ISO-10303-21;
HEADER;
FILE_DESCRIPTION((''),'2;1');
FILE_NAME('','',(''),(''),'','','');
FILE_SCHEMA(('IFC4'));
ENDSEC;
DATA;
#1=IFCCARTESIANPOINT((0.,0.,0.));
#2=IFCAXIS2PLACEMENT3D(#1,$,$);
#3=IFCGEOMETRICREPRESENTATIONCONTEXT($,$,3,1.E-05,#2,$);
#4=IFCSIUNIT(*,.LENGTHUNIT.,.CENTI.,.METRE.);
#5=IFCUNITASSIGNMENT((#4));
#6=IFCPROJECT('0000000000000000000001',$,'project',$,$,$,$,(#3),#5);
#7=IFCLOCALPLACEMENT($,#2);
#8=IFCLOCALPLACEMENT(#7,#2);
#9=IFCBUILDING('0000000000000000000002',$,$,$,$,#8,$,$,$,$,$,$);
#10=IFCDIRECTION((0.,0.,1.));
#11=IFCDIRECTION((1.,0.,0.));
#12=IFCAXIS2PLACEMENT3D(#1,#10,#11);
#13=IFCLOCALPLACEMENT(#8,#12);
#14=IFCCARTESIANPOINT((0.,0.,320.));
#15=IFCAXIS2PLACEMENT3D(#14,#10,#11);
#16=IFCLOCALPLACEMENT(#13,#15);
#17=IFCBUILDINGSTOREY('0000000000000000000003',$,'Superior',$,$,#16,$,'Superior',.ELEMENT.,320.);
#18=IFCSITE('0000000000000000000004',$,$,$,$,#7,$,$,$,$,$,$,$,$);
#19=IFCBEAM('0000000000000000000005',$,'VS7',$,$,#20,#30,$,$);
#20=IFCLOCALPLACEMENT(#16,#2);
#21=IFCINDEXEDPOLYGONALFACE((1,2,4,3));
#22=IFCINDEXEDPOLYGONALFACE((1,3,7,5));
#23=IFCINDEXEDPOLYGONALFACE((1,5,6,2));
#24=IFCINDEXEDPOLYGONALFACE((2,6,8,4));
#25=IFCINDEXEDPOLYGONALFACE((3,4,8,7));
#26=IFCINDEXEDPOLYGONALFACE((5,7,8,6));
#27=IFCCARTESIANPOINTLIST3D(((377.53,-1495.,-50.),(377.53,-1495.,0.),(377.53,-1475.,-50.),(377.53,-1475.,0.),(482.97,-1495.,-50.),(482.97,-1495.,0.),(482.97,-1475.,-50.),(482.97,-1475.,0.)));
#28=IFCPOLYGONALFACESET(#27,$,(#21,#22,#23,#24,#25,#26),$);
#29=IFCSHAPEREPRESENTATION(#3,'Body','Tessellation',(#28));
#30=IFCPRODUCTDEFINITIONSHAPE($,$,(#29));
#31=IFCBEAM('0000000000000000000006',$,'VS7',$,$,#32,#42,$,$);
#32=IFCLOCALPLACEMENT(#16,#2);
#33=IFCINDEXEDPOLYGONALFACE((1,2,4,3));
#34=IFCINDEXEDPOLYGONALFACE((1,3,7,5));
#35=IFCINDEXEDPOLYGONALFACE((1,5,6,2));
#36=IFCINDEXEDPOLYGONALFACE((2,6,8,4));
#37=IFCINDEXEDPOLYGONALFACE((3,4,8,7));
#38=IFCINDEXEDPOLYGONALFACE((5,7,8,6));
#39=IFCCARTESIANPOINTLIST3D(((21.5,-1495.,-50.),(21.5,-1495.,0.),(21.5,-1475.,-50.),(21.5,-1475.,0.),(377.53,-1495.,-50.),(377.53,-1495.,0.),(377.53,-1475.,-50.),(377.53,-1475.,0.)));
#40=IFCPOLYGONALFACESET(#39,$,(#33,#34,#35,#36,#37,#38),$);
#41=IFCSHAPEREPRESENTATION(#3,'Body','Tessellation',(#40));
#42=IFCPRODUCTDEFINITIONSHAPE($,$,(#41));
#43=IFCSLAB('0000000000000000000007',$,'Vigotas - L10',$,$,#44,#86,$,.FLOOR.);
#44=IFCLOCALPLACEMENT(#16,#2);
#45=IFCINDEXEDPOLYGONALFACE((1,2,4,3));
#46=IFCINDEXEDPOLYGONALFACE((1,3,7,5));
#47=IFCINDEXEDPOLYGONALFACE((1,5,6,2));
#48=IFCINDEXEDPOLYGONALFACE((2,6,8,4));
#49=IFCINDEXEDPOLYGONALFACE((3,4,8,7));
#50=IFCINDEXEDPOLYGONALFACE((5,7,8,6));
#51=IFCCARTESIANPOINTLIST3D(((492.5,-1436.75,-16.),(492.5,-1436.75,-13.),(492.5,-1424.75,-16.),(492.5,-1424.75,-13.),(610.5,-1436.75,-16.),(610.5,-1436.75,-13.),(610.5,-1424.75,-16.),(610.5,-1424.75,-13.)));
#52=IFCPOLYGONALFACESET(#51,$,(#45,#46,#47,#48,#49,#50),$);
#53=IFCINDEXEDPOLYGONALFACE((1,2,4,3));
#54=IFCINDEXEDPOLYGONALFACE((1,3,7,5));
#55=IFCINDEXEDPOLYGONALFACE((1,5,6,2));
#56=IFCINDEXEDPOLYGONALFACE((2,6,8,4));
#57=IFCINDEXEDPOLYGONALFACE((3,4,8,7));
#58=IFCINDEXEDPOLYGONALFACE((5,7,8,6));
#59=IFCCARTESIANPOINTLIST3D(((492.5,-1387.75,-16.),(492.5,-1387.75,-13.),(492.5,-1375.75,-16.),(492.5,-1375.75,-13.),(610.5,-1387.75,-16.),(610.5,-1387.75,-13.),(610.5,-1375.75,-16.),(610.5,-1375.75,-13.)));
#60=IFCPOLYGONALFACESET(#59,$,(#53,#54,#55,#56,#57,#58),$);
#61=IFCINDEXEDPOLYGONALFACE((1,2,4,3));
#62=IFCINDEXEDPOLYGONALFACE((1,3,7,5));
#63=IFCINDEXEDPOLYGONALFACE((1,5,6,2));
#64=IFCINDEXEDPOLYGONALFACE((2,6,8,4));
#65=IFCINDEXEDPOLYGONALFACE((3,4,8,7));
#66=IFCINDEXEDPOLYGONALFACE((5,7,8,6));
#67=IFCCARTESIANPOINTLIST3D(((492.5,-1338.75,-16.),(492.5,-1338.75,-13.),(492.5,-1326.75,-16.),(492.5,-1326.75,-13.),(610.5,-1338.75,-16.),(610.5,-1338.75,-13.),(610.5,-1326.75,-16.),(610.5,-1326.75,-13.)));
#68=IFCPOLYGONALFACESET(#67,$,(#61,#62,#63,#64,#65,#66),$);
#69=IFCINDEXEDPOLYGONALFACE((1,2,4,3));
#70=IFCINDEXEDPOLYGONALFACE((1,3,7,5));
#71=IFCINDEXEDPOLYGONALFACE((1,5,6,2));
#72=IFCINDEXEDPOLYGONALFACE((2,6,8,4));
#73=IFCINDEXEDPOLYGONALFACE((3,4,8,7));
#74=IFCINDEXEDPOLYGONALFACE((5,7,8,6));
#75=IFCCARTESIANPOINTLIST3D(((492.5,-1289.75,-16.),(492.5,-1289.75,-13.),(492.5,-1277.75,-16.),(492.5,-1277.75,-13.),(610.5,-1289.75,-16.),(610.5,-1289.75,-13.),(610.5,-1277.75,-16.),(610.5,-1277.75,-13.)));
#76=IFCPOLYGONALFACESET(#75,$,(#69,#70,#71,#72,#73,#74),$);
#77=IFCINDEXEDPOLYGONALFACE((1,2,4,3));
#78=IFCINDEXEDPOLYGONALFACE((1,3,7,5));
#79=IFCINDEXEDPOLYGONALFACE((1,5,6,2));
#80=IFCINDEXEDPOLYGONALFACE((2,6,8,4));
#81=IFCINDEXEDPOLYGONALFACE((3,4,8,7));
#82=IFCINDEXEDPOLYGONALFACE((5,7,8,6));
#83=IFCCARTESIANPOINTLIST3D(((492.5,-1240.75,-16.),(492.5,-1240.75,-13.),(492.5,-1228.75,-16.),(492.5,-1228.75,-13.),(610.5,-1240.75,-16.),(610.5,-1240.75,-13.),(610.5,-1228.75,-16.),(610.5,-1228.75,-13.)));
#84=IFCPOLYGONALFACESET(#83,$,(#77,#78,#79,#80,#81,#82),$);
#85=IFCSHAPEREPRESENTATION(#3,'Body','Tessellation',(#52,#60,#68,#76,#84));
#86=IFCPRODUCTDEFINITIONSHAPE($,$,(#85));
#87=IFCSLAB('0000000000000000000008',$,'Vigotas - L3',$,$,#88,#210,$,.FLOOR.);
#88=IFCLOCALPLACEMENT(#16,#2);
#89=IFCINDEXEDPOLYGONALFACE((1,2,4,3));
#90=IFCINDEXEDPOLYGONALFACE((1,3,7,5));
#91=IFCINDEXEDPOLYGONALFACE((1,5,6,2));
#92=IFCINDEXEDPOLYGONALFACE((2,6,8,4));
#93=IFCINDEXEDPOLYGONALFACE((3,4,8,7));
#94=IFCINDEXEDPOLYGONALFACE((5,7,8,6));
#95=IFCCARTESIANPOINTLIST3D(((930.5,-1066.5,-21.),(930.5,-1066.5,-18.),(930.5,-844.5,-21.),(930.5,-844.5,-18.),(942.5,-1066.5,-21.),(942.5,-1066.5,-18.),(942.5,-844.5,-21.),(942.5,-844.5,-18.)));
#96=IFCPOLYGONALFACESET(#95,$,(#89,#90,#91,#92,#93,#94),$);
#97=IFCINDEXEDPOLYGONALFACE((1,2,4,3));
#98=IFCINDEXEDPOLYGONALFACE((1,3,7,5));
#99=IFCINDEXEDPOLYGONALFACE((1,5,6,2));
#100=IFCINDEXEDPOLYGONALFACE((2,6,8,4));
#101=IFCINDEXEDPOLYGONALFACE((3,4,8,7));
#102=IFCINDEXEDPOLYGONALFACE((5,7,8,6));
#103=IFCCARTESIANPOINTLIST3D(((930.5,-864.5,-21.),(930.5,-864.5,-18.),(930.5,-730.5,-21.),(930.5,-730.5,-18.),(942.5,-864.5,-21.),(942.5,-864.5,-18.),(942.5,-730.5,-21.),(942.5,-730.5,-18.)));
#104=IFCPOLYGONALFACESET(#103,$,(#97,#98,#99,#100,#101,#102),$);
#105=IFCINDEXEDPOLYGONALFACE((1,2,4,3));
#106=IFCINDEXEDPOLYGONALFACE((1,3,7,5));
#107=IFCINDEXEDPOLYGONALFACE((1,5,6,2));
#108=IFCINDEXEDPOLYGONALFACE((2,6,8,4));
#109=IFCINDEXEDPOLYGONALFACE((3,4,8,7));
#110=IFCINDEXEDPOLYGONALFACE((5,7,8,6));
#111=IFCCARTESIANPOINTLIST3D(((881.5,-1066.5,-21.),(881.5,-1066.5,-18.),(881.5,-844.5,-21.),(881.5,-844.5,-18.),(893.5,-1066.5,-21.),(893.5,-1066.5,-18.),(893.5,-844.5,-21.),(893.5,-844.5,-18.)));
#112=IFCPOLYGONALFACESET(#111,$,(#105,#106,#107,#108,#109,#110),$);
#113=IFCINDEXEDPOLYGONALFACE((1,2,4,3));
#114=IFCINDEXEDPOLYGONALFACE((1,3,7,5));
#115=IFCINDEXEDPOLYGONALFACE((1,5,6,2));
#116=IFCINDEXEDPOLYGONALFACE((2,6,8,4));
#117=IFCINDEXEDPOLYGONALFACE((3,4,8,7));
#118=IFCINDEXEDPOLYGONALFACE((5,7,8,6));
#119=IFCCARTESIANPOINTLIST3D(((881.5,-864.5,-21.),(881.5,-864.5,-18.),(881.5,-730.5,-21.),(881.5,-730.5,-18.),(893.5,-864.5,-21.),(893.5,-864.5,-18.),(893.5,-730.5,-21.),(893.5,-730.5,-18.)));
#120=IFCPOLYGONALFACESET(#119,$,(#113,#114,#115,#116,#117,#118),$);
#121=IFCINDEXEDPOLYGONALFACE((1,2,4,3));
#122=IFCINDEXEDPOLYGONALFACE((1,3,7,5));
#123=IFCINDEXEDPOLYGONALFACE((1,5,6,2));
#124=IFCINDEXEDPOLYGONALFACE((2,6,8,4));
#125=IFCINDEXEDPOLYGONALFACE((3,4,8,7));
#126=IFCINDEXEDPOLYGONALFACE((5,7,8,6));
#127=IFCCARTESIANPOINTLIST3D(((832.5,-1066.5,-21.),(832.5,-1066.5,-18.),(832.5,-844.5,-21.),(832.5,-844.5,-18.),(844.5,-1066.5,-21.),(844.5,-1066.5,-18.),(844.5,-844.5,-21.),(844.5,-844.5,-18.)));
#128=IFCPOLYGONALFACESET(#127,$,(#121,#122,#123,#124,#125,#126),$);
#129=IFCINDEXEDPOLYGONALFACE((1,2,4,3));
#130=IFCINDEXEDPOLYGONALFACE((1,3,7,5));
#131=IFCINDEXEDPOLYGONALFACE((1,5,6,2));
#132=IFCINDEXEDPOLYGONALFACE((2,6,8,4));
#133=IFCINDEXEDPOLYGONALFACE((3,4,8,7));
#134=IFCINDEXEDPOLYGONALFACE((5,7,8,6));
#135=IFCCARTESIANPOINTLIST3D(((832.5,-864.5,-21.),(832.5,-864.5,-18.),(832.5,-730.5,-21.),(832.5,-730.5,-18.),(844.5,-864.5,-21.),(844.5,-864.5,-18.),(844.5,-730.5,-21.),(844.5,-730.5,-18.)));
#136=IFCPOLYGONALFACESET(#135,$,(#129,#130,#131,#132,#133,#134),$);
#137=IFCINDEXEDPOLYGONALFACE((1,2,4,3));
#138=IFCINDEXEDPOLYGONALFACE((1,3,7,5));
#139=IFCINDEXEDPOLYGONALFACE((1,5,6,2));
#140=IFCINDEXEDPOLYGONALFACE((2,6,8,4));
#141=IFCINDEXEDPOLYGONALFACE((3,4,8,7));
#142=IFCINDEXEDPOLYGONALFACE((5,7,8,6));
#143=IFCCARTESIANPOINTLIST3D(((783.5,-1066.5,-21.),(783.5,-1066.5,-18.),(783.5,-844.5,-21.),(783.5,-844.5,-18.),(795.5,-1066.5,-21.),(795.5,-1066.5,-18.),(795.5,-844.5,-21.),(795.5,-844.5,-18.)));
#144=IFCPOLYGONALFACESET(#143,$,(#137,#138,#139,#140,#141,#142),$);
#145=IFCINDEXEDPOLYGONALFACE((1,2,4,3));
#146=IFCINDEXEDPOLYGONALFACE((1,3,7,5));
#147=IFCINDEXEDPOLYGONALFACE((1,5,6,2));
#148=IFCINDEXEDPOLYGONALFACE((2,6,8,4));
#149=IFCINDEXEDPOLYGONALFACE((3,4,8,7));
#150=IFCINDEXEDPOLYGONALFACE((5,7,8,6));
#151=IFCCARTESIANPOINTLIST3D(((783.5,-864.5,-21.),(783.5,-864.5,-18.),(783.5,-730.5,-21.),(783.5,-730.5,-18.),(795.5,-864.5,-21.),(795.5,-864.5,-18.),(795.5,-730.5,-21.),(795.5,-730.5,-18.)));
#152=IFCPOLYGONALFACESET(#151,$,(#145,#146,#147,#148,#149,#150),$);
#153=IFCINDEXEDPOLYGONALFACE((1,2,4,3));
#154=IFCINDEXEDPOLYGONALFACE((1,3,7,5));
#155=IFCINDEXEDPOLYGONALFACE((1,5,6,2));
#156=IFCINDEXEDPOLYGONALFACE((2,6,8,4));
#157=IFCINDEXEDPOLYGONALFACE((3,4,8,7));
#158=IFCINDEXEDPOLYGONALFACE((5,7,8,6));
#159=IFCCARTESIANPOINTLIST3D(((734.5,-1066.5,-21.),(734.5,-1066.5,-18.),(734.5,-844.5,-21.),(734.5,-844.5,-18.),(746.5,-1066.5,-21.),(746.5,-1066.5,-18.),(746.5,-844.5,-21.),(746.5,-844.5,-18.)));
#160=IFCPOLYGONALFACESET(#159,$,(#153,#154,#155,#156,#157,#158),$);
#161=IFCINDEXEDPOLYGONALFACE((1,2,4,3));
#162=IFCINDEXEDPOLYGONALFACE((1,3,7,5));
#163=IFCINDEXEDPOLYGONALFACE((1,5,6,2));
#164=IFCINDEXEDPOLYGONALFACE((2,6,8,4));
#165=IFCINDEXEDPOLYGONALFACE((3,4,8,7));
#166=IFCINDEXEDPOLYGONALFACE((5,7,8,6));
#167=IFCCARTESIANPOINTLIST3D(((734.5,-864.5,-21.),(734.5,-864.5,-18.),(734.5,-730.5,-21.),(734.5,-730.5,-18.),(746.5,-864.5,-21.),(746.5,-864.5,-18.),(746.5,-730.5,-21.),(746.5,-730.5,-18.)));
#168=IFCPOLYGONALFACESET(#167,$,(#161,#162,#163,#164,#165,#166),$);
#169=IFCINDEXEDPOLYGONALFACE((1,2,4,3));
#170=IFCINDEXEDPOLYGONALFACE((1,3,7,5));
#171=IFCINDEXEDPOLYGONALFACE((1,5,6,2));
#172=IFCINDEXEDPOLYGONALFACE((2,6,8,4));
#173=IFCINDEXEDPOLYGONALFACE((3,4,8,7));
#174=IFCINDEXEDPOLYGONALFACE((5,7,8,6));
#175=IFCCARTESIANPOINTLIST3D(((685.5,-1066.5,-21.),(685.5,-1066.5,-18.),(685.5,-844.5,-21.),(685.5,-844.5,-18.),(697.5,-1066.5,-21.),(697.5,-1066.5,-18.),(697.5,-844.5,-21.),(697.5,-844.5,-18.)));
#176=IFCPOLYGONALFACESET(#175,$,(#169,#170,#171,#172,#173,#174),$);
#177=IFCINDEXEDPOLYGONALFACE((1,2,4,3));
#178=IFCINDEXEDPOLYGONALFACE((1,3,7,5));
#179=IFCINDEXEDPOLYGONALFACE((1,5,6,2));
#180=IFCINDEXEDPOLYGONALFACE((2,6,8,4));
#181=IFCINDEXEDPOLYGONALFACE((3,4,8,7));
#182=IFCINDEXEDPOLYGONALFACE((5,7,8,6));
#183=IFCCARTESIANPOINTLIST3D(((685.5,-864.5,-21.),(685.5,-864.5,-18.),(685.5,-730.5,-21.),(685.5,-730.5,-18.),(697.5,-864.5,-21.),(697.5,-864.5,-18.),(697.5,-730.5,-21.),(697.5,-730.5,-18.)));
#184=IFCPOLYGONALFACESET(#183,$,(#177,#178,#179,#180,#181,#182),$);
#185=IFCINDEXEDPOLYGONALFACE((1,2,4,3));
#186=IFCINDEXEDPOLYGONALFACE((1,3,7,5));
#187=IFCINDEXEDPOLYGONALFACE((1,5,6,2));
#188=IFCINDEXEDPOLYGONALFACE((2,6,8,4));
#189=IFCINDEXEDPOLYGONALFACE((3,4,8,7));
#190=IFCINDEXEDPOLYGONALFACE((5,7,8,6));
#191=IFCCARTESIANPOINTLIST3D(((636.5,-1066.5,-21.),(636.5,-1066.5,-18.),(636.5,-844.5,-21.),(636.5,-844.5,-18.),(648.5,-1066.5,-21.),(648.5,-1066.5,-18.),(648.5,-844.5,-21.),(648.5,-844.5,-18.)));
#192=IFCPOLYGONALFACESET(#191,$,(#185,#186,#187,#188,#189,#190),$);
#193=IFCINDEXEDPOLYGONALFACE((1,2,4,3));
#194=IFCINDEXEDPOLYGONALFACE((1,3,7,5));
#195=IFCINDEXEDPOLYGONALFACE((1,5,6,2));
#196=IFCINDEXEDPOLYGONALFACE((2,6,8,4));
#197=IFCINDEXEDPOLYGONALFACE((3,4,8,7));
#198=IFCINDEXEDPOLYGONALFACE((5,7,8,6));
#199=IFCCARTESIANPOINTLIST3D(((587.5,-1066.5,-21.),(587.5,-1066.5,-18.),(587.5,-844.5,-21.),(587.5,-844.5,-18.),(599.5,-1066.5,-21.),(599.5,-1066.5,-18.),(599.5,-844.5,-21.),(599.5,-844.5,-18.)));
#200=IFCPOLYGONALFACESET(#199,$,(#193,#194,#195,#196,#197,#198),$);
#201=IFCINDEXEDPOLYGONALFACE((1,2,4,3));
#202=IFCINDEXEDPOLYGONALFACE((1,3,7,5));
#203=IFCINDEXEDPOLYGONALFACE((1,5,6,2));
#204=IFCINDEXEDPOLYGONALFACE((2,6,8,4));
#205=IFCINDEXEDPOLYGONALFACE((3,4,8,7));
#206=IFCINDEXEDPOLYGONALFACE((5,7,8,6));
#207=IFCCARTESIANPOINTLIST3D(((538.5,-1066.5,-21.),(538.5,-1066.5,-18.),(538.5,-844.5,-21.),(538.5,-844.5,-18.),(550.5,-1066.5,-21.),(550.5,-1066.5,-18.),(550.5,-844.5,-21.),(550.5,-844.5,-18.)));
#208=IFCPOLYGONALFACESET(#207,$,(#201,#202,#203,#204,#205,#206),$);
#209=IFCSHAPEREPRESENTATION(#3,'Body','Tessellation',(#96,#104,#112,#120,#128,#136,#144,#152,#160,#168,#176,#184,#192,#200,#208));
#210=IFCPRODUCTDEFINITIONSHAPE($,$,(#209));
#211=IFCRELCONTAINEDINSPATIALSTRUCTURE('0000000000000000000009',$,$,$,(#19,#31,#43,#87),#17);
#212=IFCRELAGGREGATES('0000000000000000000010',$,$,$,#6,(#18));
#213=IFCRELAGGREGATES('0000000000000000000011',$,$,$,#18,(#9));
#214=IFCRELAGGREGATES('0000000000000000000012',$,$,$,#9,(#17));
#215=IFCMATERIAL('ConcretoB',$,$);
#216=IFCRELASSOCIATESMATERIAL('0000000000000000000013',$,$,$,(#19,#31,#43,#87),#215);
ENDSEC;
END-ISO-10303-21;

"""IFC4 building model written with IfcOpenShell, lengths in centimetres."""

from ifc_helpers import new_model, si_unit, frame, origin, origin_with_axes, place, context, project, spatial, polyline, outline, extrude, material, element, save


model = new_model("IFC4")

# Units and contexts
context_of_model = context(None, 3, precision=1e-05, world=origin())
ifc_project = project(units=[si_unit("LENGTHUNIT", "METRE", prefix="CENTI")], contexts=[context_of_model])

# Site, building, storey
site_placement = place(None, origin())
site = spatial("IfcSite", under=ifc_project, at=site_placement)
building_placement = place(site_placement, origin())
building = spatial("IfcBuilding", under=site, at=building_placement)
placement = place(building_placement, origin_with_axes())
storey_placement = place(placement, frame((0.0, 0.0, 320.0), z_axis=(0.0, 0.0, 1.0), x_axis=(1.0, 0.0, 0.0)))
storey = spatial("IfcBuildingStorey", under=building, at=storey_placement, Name="Superior", LongName="Superior", CompositionType="ELEMENT", Elevation=320.0)

# Shared definitions
ifc_material = material(Name="ConcretoB")

# Beams
beam_1_placement = place(storey_placement, frame((430.25, -1485.0, 0.0), z_axis=(0.0, 0.0, 1.0), x_axis=(1.0, 0.0, 0.0)))
element("IfcBeam", 1, at=beam_1_placement, inside=storey, material=ifc_material, Name="VS7", context=context_of_model, shape_type="SolidModel", body=[
    extrude(outline(polyline([(-10.0, -25.0), (10.0, -25.0), (10.0, 25.0), (-10.0, 25.0), (-10.0, -25.0)])), frame((-52.72, 0.0, -25.0), z_axis=(1.0, 0.0, 0.0), x_axis=(0.0, -1.0, 0.0)), (0.0, 0.0, 1.0), 105.44),
])
beam_2_placement = place(storey_placement, frame((199.51, -1485.0, 0.0), z_axis=(0.0, 0.0, 1.0), x_axis=(1.0, 0.0, 0.0)))
element("IfcBeam", 2, at=beam_2_placement, inside=storey, material=ifc_material, Name="VS7", context=context_of_model, shape_type="SolidModel", body=[
    extrude(outline(polyline([(-10.0, -25.0), (10.0, -25.0), (10.0, 25.0), (-10.0, 25.0), (-10.0, -25.0)])), frame((-178.01, 0.0, -25.0), z_axis=(1.0, 0.0, 0.0), x_axis=(0.0, -1.0, 0.0)), (0.0, 0.0, 1.0), 356.03),
])

# Slabs
slab_1_placement = place(storey_placement, frame((551.5, -1332.75, -13.0), z_axis=(0.0, 0.0, 1.0), x_axis=(1.0, 0.0, 0.0)))
element("IfcSlab", 3, at=slab_1_placement, inside=storey, material=ifc_material, Name="Vigotas - L10", PredefinedType="FLOOR", context=context_of_model, shape_type="SolidModel", body=[
    extrude(outline(polyline([(6.0, 1.5), (-6.0, 1.5), (-6.0, -1.5), (6.0, -1.5), (6.0, 1.5), (6.0, 1.5)])), frame((-59.0, -98.0, -1.5), z_axis=(1.0, 0.0, 0.0), x_axis=(0.0, -1.0, 0.0)), (0.0, 0.0, 1.0), 118.0),
    extrude(outline(polyline([(6.0, 1.5), (-6.0, 1.5), (-6.0, -1.5), (6.0, -1.5), (6.0, 1.5), (6.0, 1.5)])), frame((-59.0, -49.0, -1.5), z_axis=(1.0, 0.0, 0.0), x_axis=(0.0, -1.0, 0.0)), (0.0, 0.0, 1.0), 118.0),
    extrude(outline(polyline([(6.0, 1.5), (-6.0, 1.5), (-6.0, -1.5), (6.0, -1.5), (6.0, 1.5), (6.0, 1.5)])), frame((-59.0, 0.0, -1.5), z_axis=(1.0, 0.0, 0.0), x_axis=(0.0, -1.0, 0.0)), (0.0, 0.0, 1.0), 118.0),
    extrude(outline(polyline([(6.0, 1.5), (-6.0, 1.5), (-6.0, -1.5), (6.0, -1.5), (6.0, 1.5), (6.0, 1.5)])), frame((-59.0, 49.0, -1.5), z_axis=(1.0, 0.0, 0.0), x_axis=(0.0, -1.0, 0.0)), (0.0, 0.0, 1.0), 118.0),
    extrude(outline(polyline([(6.0, 1.5), (-6.0, 1.5), (-6.0, -1.5), (6.0, -1.5), (6.0, 1.5), (6.0, 1.5)])), frame((-59.0, 98.0, -1.5), z_axis=(1.0, 0.0, 0.0), x_axis=(0.0, -1.0, 0.0)), (0.0, 0.0, 1.0), 118.0),
])
slab_2_placement = place(storey_placement, frame((740.5, -898.5, -18.0), z_axis=(0.0, 0.0, 1.0), x_axis=(1.0, 0.0, 0.0)))
element("IfcSlab", 4, at=slab_2_placement, inside=storey, material=ifc_material, Name="Vigotas - L3", PredefinedType="FLOOR", context=context_of_model, shape_type="SolidModel", body=[
    extrude(outline(polyline([(6.0, 1.5), (-6.0, 1.5), (-6.0, -1.5), (6.0, -1.5), (6.0, 1.5), (6.0, 1.5)])), frame((196.0, -168.0, -1.5), z_axis=(0.0, 1.0, 0.0), x_axis=(1.0, 0.0, 0.0)), (0.0, 0.0, 1.0), 222.0),
    extrude(outline(polyline([(6.0, 1.5), (-6.0, 1.5), (-6.0, -1.5), (6.0, -1.5), (6.0, 1.5), (6.0, 1.5)])), frame((196.0, 34.0, -1.5), z_axis=(0.0, 1.0, 0.0), x_axis=(1.0, 0.0, 0.0)), (0.0, 0.0, 1.0), 134.0),
    extrude(outline(polyline([(6.0, 1.5), (-6.0, 1.5), (-6.0, -1.5), (6.0, -1.5), (6.0, 1.5), (6.0, 1.5)])), frame((147.0, -168.0, -1.5), z_axis=(0.0, 1.0, 0.0), x_axis=(1.0, 0.0, 0.0)), (0.0, 0.0, 1.0), 222.0),
    extrude(outline(polyline([(6.0, 1.5), (-6.0, 1.5), (-6.0, -1.5), (6.0, -1.5), (6.0, 1.5), (6.0, 1.5)])), frame((147.0, 34.0, -1.5), z_axis=(0.0, 1.0, 0.0), x_axis=(1.0, 0.0, 0.0)), (0.0, 0.0, 1.0), 134.0),
    extrude(outline(polyline([(6.0, 1.5), (-6.0, 1.5), (-6.0, -1.5), (6.0, -1.5), (6.0, 1.5), (6.0, 1.5)])), frame((98.0, -168.0, -1.5), z_axis=(0.0, 1.0, 0.0), x_axis=(1.0, 0.0, 0.0)), (0.0, 0.0, 1.0), 222.0),
    extrude(outline(polyline([(6.0, 1.5), (-6.0, 1.5), (-6.0, -1.5), (6.0, -1.5), (6.0, 1.5), (6.0, 1.5)])), frame((98.0, 34.0, -1.5), z_axis=(0.0, 1.0, 0.0), x_axis=(1.0, 0.0, 0.0)), (0.0, 0.0, 1.0), 134.0),
    extrude(outline(polyline([(6.0, 1.5), (-6.0, 1.5), (-6.0, -1.5), (6.0, -1.5), (6.0, 1.5), (6.0, 1.5)])), frame((49.0, -168.0, -1.5), z_axis=(0.0, 1.0, 0.0), x_axis=(1.0, 0.0, 0.0)), (0.0, 0.0, 1.0), 222.0),
    extrude(outline(polyline([(6.0, 1.5), (-6.0, 1.5), (-6.0, -1.5), (6.0, -1.5), (6.0, 1.5), (6.0, 1.5)])), frame((49.0, 34.0, -1.5), z_axis=(0.0, 1.0, 0.0), x_axis=(1.0, 0.0, 0.0)), (0.0, 0.0, 1.0), 134.0),
    extrude(outline(polyline([(6.0, 1.5), (-6.0, 1.5), (-6.0, -1.5), (6.0, -1.5), (6.0, 1.5), (6.0, 1.5)])), frame((0.0, -168.0, -1.5), z_axis=(0.0, 1.0, 0.0), x_axis=(1.0, 0.0, 0.0)), (0.0, 0.0, 1.0), 222.0),
    extrude(outline(polyline([(6.0, 1.5), (-6.0, 1.5), (-6.0, -1.5), (6.0, -1.5), (6.0, 1.5), (6.0, 1.5)])), frame((0.0, 34.0, -1.5), z_axis=(0.0, 1.0, 0.0), x_axis=(1.0, 0.0, 0.0)), (0.0, 0.0, 1.0), 134.0),
    extrude(outline(polyline([(6.0, 1.5), (-6.0, 1.5), (-6.0, -1.5), (6.0, -1.5), (6.0, 1.5), (6.0, 1.5)])), frame((-49.0, -168.0, -1.5), z_axis=(0.0, 1.0, 0.0), x_axis=(1.0, 0.0, 0.0)), (0.0, 0.0, 1.0), 222.0),
    extrude(outline(polyline([(6.0, 1.5), (-6.0, 1.5), (-6.0, -1.5), (6.0, -1.5), (6.0, 1.5), (6.0, 1.5)])), frame((-49.0, 34.0, -1.5), z_axis=(0.0, 1.0, 0.0), x_axis=(1.0, 0.0, 0.0)), (0.0, 0.0, 1.0), 134.0),
    extrude(outline(polyline([(6.0, 1.5), (-6.0, 1.5), (-6.0, -1.5), (6.0, -1.5), (6.0, 1.5), (6.0, 1.5)])), frame((-98.0, -168.0, -1.5), z_axis=(0.0, 1.0, 0.0), x_axis=(1.0, 0.0, 0.0)), (0.0, 0.0, 1.0), 222.0),
    extrude(outline(polyline([(6.0, 1.5), (-6.0, 1.5), (-6.0, -1.5), (6.0, -1.5), (6.0, 1.5), (6.0, 1.5)])), frame((-147.0, -168.0, -1.5), z_axis=(0.0, 1.0, 0.0), x_axis=(1.0, 0.0, 0.0)), (0.0, 0.0, 1.0), 222.0),
    extrude(outline(polyline([(6.0, 1.5), (-6.0, 1.5), (-6.0, -1.5), (6.0, -1.5), (6.0, 1.5), (6.0, 1.5)])), frame((-196.0, -168.0, -1.5), z_axis=(0.0, 1.0, 0.0), x_axis=(1.0, 0.0, 0.0)), (0.0, 0.0, 1.0), 222.0),
])

save(model, "model.ifc")
